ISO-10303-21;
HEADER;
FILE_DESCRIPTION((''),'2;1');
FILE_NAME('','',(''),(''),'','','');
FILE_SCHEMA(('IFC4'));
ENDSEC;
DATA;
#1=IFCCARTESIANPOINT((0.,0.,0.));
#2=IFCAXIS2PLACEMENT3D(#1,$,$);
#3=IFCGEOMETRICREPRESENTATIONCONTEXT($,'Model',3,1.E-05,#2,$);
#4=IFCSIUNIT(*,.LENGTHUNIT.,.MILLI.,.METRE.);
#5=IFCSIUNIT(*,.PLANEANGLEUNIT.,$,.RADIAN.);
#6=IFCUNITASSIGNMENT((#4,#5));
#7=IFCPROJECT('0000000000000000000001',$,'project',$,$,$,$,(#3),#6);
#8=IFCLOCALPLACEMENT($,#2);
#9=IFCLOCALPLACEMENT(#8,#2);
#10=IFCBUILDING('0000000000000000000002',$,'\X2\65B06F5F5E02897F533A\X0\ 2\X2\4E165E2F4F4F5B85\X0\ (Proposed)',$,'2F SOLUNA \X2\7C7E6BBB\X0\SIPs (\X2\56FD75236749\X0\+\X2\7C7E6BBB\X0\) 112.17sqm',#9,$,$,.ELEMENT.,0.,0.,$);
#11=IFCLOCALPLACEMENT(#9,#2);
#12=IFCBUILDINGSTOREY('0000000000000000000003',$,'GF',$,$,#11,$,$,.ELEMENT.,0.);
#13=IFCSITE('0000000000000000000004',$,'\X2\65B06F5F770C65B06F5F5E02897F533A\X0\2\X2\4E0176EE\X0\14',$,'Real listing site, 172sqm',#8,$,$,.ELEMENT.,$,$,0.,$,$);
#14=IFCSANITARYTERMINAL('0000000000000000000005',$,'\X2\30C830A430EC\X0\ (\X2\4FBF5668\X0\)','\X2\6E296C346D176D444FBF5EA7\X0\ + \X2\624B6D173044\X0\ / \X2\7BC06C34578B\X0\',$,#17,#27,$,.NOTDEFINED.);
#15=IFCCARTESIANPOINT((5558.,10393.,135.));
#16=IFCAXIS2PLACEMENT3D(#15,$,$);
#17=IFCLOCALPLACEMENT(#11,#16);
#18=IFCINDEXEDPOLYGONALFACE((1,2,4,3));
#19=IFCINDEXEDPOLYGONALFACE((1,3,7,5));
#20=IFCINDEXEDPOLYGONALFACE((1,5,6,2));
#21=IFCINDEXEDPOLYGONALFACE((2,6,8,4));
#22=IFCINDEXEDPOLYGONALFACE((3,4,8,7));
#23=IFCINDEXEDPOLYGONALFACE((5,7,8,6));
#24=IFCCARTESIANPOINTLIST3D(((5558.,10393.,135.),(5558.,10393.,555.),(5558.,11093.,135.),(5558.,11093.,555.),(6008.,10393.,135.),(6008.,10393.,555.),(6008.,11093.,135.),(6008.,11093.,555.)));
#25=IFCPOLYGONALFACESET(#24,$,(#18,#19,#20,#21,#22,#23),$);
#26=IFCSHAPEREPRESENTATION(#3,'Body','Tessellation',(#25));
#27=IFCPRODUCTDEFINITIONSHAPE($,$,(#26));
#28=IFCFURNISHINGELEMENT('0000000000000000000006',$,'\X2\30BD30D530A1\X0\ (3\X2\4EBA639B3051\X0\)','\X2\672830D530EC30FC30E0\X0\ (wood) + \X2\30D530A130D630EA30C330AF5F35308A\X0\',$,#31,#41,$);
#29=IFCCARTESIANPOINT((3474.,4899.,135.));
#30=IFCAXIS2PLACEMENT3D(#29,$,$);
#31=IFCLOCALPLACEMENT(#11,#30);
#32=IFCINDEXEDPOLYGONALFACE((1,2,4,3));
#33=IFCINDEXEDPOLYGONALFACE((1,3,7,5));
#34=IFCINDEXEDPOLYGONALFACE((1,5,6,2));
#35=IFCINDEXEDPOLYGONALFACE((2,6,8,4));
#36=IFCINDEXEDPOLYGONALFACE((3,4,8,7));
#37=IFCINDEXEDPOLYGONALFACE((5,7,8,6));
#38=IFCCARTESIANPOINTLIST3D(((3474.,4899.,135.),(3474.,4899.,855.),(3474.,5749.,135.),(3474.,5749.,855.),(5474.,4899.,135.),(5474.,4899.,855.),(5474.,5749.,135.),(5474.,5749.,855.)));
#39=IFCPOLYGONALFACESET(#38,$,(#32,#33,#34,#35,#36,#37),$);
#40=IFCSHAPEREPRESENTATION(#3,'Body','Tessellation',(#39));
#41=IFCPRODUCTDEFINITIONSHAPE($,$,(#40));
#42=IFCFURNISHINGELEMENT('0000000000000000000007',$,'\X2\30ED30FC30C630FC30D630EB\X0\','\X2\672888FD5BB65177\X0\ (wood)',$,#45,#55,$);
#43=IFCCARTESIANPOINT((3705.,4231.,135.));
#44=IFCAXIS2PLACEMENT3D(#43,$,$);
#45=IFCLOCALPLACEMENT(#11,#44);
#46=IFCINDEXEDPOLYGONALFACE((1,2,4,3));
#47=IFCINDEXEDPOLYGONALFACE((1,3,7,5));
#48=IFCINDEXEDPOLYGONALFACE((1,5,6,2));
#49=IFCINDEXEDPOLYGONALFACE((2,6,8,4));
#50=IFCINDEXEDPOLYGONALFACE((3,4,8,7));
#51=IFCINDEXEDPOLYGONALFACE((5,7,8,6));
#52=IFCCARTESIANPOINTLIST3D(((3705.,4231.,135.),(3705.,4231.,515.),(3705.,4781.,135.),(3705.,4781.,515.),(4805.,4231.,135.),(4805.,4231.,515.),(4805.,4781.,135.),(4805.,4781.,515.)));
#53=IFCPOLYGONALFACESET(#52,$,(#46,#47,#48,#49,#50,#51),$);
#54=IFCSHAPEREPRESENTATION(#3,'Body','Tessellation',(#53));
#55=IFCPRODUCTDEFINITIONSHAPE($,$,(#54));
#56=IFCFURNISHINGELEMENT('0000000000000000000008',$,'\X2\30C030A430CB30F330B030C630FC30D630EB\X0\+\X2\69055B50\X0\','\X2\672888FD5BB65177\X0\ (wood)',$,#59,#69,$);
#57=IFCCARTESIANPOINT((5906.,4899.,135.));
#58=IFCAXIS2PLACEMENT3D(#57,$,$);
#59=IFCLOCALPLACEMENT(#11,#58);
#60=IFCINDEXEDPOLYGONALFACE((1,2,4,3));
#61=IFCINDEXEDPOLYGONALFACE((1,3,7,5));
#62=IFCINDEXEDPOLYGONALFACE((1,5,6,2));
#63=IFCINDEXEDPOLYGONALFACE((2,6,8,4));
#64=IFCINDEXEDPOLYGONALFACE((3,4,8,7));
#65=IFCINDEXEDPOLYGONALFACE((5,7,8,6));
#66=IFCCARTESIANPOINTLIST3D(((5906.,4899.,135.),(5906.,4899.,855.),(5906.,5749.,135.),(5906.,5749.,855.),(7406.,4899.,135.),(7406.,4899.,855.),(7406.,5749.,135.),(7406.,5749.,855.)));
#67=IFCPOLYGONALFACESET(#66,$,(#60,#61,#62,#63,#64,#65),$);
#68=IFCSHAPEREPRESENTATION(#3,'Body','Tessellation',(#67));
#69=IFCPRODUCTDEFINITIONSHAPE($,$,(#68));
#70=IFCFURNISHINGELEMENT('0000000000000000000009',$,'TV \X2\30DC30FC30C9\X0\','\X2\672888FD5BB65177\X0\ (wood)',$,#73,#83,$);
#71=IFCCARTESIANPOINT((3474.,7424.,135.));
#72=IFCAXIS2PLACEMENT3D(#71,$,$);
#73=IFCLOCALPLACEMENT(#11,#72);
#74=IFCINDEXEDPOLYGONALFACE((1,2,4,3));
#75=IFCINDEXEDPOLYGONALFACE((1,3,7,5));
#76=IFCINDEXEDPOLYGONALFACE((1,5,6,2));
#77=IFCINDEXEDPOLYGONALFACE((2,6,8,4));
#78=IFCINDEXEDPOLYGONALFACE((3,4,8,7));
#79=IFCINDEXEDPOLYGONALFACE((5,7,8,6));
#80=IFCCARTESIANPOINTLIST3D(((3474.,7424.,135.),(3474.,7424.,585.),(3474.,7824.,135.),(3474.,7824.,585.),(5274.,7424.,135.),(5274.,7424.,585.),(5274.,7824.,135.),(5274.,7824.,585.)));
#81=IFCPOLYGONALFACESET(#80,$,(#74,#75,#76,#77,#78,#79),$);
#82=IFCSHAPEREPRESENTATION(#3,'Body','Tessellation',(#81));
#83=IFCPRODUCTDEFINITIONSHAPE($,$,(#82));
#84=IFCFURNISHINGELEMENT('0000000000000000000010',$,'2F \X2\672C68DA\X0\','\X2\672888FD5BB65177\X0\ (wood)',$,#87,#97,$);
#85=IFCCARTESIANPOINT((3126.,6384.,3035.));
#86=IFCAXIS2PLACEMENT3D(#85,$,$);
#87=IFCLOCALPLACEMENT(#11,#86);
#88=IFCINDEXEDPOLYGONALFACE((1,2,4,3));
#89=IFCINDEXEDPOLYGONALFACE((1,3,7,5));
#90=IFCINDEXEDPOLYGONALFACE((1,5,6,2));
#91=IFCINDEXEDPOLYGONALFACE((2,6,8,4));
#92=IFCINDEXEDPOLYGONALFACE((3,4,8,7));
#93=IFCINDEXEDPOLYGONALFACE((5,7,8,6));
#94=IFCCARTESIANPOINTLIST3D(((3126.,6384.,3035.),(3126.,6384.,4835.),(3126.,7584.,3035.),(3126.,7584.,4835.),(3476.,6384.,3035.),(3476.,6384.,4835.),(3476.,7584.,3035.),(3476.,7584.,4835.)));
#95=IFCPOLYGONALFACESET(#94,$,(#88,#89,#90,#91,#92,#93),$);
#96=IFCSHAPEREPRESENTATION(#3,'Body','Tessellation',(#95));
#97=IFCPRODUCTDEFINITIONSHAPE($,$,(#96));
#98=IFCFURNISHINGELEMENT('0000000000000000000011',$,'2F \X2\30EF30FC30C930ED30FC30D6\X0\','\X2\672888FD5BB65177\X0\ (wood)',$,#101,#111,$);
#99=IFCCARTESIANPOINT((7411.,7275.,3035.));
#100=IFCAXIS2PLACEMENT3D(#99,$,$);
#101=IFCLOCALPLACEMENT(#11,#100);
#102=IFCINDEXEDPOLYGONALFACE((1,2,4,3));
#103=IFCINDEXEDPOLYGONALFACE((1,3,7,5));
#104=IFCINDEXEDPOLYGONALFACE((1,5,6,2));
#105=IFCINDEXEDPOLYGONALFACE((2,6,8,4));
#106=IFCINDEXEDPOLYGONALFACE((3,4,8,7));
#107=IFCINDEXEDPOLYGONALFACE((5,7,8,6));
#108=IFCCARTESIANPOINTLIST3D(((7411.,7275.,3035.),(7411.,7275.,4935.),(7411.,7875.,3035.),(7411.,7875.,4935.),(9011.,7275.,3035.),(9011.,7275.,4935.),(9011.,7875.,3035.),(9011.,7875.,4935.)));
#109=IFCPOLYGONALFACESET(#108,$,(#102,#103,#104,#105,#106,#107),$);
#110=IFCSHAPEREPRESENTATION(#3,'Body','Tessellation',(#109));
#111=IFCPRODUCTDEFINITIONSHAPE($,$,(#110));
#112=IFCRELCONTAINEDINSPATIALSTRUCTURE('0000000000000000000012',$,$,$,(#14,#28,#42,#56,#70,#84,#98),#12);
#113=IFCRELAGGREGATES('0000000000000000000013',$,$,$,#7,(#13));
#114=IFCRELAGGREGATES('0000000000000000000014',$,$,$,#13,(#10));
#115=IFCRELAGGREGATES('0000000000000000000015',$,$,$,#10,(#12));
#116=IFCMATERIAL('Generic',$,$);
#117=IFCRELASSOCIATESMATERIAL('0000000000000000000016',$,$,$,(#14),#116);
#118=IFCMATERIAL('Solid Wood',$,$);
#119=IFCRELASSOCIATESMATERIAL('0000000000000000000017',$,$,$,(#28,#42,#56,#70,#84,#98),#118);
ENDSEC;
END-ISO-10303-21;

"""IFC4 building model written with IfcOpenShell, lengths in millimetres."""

from ifc_helpers import new_model, si_unit, frame, frame_2d, origin, place, context, project, spatial, rectangle, extrude, material, element, save


model = new_model("IFC4")

# Units and contexts
model_context = context("Model", 3, precision=1e-05, world=origin())
ifc_project = project(units=[si_unit("LENGTHUNIT", "METRE", prefix="MILLI"), si_unit("PLANEANGLEUNIT", "RADIAN")], contexts=[model_context])

# Site, building, storey
site_placement = place(None, origin())
site = spatial("IfcSite", under=ifc_project, at=site_placement, Name="新潟県新潟市西区2丁目14", ObjectType="Real listing site, 172sqm", CompositionType="ELEMENT", RefElevation=0.0)
building_placement = place(site_placement, origin())
building = spatial("IfcBuilding", under=site, at=building_placement, Name="新潟市西区 2世帯住宅 (Proposed)", ObjectType="2F SOLUNA 籾殻SIPs (国産杉+籾殻) 112.17sqm", CompositionType="ELEMENT", ElevationOfRefHeight=0.0, ElevationOfTerrain=0.0)
storey_placement = place(building_placement, origin())
storey = spatial("IfcBuildingStorey", under=building, at=storey_placement, Name="GF", CompositionType="ELEMENT", Elevation=0.0)

# Shared definitions
ifc_material_1 = material(Name="Generic")

# Shared definitions
ifc_material_2 = material(Name="Solid Wood")

# Sanitary terminal
sanitary_terminal_1_placement = place(storey_placement, frame((5558.0, 10393.0, 135.0)))
element("IfcSanitaryTerminal", 1, at=sanitary_terminal_1_placement, inside=storey, material=ifc_material_1, Name="トイレ (便器)", Description="温水洗浄便座 + 手洗い / 節水型", PredefinedType="NOTDEFINED", context=model_context, shape_type="SweptSolid", body=[
    extrude(rectangle(XDim=450.0, YDim=700.0, at=frame_2d((225.0, 350.0))), frame((5558.0, 10393.0, 135.0)), (0.0, 0.0, 1.0), 420.0),
])

# Furnishing elements
furnishing_1_placement = place(storey_placement, frame((3474.0, 4899.0, 135.0)))
element("IfcFurnishingElement", 2, at=furnishing_1_placement, inside=storey, material=ifc_material_2, Name="ソファ (3人掛け)", Description="木フレーム (wood) + ファブリック張り", context=model_context, shape_type="SweptSolid", body=[
    extrude(rectangle(XDim=2000.0, YDim=850.0, at=frame_2d((1000.0, 425.0))), frame((3474.0, 4899.0, 135.0)), (0.0, 0.0, 1.0), 720.0),
])
furnishing_2_placement = place(storey_placement, frame((3705.0, 4231.0, 135.0)))
element("IfcFurnishingElement", 3, at=furnishing_2_placement, inside=storey, material=ifc_material_2, Name="ローテーブル", Description="木製家具 (wood)", context=model_context, shape_type="SweptSolid", body=[
    extrude(rectangle(XDim=1100.0, YDim=550.0, at=frame_2d((550.0, 275.0))), frame((3705.0, 4231.0, 135.0)), (0.0, 0.0, 1.0), 380.0),
])
furnishing_3_placement = place(storey_placement, frame((5906.0, 4899.0, 135.0)))
element("IfcFurnishingElement", 4, at=furnishing_3_placement, inside=storey, material=ifc_material_2, Name="ダイニングテーブル+椅子", Description="木製家具 (wood)", context=model_context, shape_type="SweptSolid", body=[
    extrude(rectangle(XDim=1500.0, YDim=850.0, at=frame_2d((750.0, 425.0))), frame((5906.0, 4899.0, 135.0)), (0.0, 0.0, 1.0), 720.0),
])
furnishing_4_placement = place(storey_placement, frame((3474.0, 7424.0, 135.0)))
element("IfcFurnishingElement", 5, at=furnishing_4_placement, inside=storey, material=ifc_material_2, Name="TV ボード", Description="木製家具 (wood)", context=model_context, shape_type="SweptSolid", body=[
    extrude(rectangle(XDim=1800.0, YDim=400.0, at=frame_2d((900.0, 200.0))), frame((3474.0, 7424.0, 135.0)), (0.0, 0.0, 1.0), 450.0),
])
furnishing_5_placement = place(storey_placement, frame((3126.0, 6384.0, 3035.0)))
element("IfcFurnishingElement", 6, at=furnishing_5_placement, inside=storey, material=ifc_material_2, Name="2F 本棚", Description="木製家具 (wood)", context=model_context, shape_type="SweptSolid", body=[
    extrude(rectangle(XDim=350.0, YDim=1200.0, at=frame_2d((175.0, 600.0))), frame((3126.0, 6384.0, 3035.0)), (0.0, 0.0, 1.0), 1800.0),
])
furnishing_6_placement = place(storey_placement, frame((7411.0, 7275.0, 3035.0)))
element("IfcFurnishingElement", 7, at=furnishing_6_placement, inside=storey, material=ifc_material_2, Name="2F ワードローブ", Description="木製家具 (wood)", context=model_context, shape_type="SweptSolid", body=[
    extrude(rectangle(XDim=1600.0, YDim=600.0, at=frame_2d((800.0, 300.0))), frame((7411.0, 7275.0, 3035.0)), (0.0, 0.0, 1.0), 1900.0),
])

save(model, "model.ifc")
